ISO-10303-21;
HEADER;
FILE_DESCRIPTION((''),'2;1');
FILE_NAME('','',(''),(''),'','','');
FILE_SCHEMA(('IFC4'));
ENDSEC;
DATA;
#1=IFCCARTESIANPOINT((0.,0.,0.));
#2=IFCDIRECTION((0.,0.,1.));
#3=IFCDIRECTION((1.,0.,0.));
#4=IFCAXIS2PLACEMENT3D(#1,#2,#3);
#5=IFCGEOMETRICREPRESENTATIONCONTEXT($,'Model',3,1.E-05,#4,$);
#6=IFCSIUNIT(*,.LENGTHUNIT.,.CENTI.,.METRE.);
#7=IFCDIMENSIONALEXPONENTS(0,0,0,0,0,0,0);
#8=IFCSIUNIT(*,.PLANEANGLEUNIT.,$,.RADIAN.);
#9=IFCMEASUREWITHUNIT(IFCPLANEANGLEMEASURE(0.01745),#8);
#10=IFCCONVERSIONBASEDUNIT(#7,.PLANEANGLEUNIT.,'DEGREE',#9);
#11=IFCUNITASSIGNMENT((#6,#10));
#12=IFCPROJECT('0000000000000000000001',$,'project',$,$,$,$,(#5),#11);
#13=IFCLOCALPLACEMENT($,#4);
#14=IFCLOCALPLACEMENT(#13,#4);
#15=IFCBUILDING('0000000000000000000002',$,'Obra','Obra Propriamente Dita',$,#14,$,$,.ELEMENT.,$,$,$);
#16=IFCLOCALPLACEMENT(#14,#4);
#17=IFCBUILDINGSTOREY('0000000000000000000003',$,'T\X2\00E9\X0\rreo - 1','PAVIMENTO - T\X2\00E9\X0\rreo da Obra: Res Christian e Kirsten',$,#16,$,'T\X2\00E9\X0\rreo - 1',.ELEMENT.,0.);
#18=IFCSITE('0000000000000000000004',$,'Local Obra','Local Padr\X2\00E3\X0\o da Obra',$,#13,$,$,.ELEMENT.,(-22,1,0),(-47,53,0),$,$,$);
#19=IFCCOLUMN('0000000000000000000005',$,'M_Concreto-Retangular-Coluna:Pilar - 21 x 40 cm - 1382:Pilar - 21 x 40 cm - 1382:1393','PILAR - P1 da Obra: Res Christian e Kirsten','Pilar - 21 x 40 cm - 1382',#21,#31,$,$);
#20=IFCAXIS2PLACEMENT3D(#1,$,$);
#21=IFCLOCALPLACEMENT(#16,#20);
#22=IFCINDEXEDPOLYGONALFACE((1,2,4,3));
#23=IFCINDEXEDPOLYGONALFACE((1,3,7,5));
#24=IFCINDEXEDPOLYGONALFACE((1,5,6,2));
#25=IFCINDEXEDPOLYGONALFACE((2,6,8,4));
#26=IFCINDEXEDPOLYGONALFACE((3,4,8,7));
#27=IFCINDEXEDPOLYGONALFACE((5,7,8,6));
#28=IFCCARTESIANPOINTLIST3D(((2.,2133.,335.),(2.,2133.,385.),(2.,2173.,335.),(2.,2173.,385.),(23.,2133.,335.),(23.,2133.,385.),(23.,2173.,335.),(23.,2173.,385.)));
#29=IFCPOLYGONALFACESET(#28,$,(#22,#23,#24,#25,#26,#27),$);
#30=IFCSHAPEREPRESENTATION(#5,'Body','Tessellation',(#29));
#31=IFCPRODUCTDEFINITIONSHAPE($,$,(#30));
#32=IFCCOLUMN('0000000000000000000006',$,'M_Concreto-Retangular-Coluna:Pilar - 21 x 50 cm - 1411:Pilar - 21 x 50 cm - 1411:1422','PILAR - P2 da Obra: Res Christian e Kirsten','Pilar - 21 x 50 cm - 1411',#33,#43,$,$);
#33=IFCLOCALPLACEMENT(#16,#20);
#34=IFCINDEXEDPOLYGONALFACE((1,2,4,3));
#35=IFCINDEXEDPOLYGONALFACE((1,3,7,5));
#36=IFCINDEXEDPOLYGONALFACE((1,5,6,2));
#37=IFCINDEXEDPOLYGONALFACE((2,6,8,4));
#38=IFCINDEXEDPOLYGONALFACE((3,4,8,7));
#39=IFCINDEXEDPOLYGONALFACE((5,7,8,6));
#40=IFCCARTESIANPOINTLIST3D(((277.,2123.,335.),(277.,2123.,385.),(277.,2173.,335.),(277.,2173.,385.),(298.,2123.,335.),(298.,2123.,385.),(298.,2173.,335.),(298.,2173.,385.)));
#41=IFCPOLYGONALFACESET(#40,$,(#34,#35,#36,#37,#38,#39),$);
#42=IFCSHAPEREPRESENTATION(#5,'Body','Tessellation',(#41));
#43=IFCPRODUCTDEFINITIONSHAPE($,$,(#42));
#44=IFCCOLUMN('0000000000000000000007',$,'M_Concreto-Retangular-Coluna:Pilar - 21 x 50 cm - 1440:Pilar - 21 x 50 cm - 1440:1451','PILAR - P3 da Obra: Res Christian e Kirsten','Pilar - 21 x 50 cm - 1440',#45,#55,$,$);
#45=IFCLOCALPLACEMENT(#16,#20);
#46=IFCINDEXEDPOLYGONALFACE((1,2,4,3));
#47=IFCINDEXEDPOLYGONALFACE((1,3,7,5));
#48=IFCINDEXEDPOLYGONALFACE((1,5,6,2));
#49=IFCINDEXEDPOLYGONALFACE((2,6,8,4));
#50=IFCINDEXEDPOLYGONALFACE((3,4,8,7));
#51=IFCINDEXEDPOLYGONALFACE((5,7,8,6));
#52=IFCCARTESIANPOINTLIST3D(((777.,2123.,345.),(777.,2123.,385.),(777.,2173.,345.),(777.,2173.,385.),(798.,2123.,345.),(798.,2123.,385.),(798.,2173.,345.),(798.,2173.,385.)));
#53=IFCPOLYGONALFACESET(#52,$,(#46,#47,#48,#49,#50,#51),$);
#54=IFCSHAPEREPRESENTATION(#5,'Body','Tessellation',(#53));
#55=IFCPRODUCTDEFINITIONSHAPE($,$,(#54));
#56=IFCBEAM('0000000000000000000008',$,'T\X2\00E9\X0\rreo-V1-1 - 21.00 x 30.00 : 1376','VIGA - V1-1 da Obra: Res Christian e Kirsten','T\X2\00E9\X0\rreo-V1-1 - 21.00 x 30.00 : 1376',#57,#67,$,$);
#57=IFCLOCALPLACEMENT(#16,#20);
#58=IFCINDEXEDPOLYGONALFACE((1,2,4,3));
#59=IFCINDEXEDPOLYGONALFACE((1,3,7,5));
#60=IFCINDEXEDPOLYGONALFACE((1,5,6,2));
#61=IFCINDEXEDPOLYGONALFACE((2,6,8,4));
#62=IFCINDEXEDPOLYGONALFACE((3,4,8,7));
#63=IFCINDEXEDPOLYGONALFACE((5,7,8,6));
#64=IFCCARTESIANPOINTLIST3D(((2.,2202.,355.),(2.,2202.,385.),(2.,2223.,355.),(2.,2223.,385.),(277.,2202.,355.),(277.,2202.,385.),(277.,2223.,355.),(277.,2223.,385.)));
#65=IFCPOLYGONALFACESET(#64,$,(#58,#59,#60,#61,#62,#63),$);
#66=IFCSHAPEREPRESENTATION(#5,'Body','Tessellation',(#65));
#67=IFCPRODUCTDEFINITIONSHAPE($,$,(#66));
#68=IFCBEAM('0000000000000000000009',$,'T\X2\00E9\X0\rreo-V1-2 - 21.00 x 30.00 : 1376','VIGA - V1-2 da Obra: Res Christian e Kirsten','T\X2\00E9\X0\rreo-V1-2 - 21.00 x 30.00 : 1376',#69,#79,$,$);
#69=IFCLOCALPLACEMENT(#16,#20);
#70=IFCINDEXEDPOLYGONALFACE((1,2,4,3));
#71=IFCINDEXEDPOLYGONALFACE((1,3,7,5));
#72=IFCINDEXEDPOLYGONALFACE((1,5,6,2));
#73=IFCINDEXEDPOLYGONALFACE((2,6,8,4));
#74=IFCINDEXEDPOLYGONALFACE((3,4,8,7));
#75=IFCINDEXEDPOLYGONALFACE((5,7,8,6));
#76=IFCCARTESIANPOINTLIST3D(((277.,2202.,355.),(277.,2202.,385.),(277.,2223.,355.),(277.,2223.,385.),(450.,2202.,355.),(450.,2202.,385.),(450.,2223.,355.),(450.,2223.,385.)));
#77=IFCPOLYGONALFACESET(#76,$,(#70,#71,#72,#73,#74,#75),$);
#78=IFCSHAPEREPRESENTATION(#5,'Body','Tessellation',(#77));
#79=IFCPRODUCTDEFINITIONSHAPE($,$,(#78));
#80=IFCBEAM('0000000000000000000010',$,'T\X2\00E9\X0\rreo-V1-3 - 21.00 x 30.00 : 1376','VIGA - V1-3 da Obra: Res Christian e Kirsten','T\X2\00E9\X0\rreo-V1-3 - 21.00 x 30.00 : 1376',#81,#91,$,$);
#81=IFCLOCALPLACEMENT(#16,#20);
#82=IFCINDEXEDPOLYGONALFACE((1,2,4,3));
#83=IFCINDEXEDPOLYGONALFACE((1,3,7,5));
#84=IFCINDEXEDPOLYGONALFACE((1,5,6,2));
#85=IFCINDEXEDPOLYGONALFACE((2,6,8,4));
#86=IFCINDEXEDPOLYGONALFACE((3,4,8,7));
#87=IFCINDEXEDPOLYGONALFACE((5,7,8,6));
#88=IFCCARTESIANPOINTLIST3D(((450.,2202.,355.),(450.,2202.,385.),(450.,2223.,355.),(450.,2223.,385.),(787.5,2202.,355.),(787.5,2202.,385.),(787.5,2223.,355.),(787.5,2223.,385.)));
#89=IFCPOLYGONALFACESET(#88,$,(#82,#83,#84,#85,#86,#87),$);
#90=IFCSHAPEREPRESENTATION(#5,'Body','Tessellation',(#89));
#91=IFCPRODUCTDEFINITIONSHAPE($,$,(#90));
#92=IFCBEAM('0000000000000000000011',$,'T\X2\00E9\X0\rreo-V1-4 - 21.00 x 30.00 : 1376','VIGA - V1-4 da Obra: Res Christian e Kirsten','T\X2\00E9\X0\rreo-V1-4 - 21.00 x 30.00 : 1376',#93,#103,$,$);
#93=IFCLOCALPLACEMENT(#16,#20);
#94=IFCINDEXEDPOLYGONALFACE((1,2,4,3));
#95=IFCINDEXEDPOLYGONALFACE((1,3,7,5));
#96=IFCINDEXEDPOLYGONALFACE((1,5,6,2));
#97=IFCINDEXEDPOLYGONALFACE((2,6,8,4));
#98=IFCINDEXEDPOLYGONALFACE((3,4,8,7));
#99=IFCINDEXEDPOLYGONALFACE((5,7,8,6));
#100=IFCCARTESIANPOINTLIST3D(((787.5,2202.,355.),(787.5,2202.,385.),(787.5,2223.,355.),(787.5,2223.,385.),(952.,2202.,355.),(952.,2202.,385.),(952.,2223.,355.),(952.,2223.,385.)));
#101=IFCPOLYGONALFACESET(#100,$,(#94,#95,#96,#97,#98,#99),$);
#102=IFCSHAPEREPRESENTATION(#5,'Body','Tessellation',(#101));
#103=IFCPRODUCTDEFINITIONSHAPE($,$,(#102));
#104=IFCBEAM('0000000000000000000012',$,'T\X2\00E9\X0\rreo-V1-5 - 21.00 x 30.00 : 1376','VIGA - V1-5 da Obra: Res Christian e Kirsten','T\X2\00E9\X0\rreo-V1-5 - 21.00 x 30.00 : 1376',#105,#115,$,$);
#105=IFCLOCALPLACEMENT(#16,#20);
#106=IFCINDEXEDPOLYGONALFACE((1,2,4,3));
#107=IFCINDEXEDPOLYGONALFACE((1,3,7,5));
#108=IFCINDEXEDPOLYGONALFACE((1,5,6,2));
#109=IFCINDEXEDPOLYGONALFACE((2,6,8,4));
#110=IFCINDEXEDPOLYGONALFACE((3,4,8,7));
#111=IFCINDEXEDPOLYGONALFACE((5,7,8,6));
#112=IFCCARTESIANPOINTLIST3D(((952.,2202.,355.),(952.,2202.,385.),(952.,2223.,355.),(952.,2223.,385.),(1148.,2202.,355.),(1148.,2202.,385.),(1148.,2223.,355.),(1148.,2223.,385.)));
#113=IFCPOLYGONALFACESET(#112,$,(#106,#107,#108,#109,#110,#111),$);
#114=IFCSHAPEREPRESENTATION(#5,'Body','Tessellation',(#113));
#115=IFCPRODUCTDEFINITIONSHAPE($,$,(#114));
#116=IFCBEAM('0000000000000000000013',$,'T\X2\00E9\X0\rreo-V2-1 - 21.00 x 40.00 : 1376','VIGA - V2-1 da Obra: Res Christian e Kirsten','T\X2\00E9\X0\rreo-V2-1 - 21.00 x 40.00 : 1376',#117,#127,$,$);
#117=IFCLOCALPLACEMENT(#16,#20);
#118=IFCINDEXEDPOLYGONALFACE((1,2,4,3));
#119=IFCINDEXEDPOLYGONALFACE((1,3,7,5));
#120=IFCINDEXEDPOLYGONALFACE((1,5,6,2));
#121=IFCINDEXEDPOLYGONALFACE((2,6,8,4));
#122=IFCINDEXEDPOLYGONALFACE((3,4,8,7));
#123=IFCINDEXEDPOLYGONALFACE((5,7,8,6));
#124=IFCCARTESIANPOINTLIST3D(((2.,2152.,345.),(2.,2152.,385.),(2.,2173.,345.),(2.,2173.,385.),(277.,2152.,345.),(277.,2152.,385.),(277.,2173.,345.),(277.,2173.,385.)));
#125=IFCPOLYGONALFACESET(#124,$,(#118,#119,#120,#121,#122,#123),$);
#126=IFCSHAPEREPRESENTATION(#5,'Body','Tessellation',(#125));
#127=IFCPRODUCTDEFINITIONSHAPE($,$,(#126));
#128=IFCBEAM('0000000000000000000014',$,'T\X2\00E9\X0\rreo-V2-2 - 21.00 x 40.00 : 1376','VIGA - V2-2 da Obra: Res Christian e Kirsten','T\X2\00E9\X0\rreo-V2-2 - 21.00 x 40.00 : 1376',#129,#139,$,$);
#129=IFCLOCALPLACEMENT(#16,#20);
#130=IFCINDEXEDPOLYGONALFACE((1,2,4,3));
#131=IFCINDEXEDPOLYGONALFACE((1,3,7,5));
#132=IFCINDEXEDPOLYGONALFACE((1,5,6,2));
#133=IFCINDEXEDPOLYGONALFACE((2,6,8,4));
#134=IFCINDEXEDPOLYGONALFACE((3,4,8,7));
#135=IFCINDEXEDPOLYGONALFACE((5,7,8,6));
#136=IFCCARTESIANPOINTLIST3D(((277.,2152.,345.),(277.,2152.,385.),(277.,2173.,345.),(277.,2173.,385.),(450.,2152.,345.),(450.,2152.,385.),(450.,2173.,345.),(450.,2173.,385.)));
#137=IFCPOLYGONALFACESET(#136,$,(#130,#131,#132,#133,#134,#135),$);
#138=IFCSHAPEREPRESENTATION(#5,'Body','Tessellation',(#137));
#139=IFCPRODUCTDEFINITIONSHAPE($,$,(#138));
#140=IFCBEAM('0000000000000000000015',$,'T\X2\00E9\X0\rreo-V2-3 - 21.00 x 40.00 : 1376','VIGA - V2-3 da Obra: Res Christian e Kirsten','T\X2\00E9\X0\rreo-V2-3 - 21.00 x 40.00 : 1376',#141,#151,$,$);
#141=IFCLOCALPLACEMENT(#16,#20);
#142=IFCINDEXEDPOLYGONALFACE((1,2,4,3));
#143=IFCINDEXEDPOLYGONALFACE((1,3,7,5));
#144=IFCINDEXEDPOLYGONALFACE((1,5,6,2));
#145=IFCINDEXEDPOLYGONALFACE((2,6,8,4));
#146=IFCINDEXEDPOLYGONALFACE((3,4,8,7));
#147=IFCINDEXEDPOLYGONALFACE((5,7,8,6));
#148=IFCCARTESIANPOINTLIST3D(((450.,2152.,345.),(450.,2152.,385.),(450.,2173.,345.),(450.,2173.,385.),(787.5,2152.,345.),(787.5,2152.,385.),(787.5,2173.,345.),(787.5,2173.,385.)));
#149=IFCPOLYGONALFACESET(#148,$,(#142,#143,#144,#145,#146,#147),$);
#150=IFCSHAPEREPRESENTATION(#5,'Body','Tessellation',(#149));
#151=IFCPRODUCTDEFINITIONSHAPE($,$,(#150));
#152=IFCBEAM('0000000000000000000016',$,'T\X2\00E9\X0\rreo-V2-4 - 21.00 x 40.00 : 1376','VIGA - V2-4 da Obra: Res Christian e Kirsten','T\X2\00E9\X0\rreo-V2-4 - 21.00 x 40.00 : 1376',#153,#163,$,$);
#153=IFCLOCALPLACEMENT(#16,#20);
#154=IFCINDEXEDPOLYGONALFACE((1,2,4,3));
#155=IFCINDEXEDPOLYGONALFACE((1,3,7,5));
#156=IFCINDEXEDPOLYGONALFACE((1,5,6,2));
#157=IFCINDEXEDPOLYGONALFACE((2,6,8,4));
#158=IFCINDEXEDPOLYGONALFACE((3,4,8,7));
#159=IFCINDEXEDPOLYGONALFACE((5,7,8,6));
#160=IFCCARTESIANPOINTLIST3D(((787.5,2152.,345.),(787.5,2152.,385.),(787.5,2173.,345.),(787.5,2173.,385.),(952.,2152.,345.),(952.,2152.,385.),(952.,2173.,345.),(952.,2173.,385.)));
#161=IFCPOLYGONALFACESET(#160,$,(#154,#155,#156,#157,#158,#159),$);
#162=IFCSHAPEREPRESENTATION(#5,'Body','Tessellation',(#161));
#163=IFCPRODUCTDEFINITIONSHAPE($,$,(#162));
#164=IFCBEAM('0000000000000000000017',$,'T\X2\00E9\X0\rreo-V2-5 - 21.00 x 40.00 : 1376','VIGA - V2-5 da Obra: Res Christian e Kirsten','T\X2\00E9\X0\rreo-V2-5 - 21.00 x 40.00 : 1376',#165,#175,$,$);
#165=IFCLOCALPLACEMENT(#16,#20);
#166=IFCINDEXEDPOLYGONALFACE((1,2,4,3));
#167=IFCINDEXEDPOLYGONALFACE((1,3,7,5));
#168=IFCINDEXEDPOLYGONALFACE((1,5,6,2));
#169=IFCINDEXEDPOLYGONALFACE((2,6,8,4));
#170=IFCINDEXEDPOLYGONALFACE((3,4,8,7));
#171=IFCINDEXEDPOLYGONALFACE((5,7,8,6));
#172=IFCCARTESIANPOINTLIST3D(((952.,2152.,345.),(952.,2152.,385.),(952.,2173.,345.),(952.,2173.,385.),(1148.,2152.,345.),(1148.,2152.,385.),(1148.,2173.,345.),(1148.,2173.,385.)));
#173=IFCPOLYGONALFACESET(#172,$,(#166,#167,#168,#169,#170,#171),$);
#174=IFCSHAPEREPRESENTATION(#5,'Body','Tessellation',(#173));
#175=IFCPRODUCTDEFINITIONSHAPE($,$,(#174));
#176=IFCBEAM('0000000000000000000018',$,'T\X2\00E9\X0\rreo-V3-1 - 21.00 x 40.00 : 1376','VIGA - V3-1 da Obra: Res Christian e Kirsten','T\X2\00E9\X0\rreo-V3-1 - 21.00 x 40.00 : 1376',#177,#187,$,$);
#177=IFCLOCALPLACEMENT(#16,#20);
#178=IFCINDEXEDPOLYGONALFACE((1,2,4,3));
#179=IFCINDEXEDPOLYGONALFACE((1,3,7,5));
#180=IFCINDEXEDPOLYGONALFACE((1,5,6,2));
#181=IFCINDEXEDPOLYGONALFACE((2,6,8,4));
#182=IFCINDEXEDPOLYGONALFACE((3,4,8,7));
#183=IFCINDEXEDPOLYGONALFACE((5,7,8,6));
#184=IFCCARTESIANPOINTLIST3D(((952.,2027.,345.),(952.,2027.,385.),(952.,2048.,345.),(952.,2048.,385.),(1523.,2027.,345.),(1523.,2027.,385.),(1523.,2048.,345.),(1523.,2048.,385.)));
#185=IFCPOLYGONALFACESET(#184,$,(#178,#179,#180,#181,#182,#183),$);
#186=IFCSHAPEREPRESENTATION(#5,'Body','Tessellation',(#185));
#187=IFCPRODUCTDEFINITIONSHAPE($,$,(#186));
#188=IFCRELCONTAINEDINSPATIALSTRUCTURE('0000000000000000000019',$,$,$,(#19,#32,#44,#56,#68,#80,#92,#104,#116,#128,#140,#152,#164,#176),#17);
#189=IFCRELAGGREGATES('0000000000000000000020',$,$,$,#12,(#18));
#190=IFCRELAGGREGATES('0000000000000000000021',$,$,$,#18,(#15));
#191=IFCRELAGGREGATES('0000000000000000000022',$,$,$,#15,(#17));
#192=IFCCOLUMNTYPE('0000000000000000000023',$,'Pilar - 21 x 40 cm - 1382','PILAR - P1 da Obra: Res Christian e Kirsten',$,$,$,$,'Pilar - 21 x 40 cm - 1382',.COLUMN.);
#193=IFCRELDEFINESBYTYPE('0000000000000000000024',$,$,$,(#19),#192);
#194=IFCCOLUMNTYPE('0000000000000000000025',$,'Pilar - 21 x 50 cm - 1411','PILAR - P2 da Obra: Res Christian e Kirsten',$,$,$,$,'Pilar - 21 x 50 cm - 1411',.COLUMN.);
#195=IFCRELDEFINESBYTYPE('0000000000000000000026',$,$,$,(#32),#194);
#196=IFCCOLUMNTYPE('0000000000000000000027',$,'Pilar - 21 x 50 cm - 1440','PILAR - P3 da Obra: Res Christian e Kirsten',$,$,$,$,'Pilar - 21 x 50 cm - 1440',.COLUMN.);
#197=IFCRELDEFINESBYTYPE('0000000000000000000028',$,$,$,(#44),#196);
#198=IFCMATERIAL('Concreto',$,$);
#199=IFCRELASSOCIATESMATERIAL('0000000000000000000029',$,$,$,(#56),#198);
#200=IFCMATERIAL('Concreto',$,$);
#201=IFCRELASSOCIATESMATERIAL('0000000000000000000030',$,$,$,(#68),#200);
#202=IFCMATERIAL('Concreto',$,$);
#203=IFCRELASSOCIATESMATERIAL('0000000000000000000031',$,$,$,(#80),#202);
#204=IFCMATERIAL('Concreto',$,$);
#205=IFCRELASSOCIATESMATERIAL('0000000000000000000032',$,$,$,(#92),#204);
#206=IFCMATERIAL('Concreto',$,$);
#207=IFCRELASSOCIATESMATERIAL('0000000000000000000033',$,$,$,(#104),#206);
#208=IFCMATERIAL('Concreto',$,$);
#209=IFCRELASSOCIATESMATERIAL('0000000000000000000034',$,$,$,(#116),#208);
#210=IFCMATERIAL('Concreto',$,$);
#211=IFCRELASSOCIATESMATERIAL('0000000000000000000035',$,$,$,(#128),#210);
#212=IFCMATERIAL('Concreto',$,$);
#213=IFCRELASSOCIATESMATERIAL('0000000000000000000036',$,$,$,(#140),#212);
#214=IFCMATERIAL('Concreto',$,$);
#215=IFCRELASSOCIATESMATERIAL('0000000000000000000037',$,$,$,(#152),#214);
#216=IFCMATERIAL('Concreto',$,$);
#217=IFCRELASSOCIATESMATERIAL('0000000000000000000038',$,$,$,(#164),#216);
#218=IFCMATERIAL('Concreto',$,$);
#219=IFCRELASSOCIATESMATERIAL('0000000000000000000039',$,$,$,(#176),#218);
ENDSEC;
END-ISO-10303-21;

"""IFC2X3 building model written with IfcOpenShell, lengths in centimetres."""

from ifc_helpers import new_model, entity, si_unit, converted_unit, frame, origin, origin_with_axes, origin_2d_with_axis, place, context, project, spatial, polyline, rectangle, outline, extrude, source, transform, mapped, material, type_object, type_shapes, element, save


model = new_model("IFC2X3")

# Units and contexts
model_context = context("Model", 3, precision=1e-05, world=origin_with_axes())
ifc_project = project(units=[si_unit("LENGTHUNIT", "METRE", prefix="CENTI"), converted_unit("PLANEANGLEUNIT", "DEGREE", entity("IfcPlaneAngleMeasure", 0.01745), si_unit("PLANEANGLEUNIT", "RADIAN"), dimensions=[0, 0, 0, 0, 0, 0, 0])], contexts=[model_context])

# Site, building, storey
site_placement = place(None, origin_with_axes())
site = spatial("IfcSite", under=ifc_project, at=site_placement, Name="Local Obra", Description="Local Padrão da Obra", CompositionType="ELEMENT", RefLatitude=(-22, 1, 0), RefLongitude=(-47, 53, 0))
building_placement = place(site_placement, origin_with_axes())
building = spatial("IfcBuilding", under=site, at=building_placement, Name="Obra", Description="Obra Propriamente Dita", CompositionType="ELEMENT")
storey_placement = place(building_placement, origin_with_axes())
storey = spatial("IfcBuildingStorey", under=building, at=storey_placement, Name="Térreo - 1", Description="PAVIMENTO - Térreo da Obra: Res Christian e Kirsten", LongName="Térreo - 1", CompositionType="ELEMENT", Elevation=0.0)

# Columns
column_type_1 = type_object("IfcColumnType", Name="Pilar - 21 x 40 cm - 1382", Description="PILAR - P1 da Obra: Res Christian e Kirsten", ElementType="Pilar - 21 x 40 cm - 1382", PredefinedType="COLUMN")
shared_shape_1 = source(origin(), model_context, "Body", "SweptSolid", [
    extrude(rectangle(XDim=21.0, YDim=40.0, at=origin_2d_with_axis()), origin(), (0.0, 0.0, 1.0), 50.0),
])
type_shapes(column_type_1, [shared_shape_1])
column_1_placement = place(storey_placement, frame((12.5, 2153.0, 335.0), z_axis=(0.0, 0.0, 1.0), x_axis=(1.0, 0.0, 0.0)))
element("IfcColumn", 1, at=column_1_placement, inside=storey, type_object=column_type_1, Name="M_Concreto-Retangular-Coluna:Pilar - 21 x 40 cm - 1382:Pilar - 21 x 40 cm - 1382:1393", Description="PILAR - P1 da Obra: Res Christian e Kirsten", ObjectType="Pilar - 21 x 40 cm - 1382", context=model_context, shape_type="MappedRepresentation", body=[
    mapped(shared_shape_1, transform((0.0, 0.0, 0.0), scale=1.0)),
])
column_type_2 = type_object("IfcColumnType", Name="Pilar - 21 x 50 cm - 1411", Description="PILAR - P2 da Obra: Res Christian e Kirsten", ElementType="Pilar - 21 x 50 cm - 1411", PredefinedType="COLUMN")
shared_shape_2 = source(origin(), model_context, "Body", "SweptSolid", [
    extrude(rectangle(XDim=21.0, YDim=50.0, at=origin_2d_with_axis()), origin(), (0.0, 0.0, 1.0), 50.0),
])
type_shapes(column_type_2, [shared_shape_2])
column_2_placement = place(storey_placement, frame((287.5, 2148.0, 335.0), z_axis=(0.0, 0.0, 1.0), x_axis=(1.0, 0.0, 0.0)))
element("IfcColumn", 2, at=column_2_placement, inside=storey, type_object=column_type_2, Name="M_Concreto-Retangular-Coluna:Pilar - 21 x 50 cm - 1411:Pilar - 21 x 50 cm - 1411:1422", Description="PILAR - P2 da Obra: Res Christian e Kirsten", ObjectType="Pilar - 21 x 50 cm - 1411", context=model_context, shape_type="MappedRepresentation", body=[
    mapped(shared_shape_2, transform((0.0, 0.0, 0.0), scale=1.0)),
])
column_type_3 = type_object("IfcColumnType", Name="Pilar - 21 x 50 cm - 1440", Description="PILAR - P3 da Obra: Res Christian e Kirsten", ElementType="Pilar - 21 x 50 cm - 1440", PredefinedType="COLUMN")
shared_shape_3 = source(origin(), model_context, "Body", "SweptSolid", [
    extrude(rectangle(XDim=21.0, YDim=50.0, at=origin_2d_with_axis()), origin(), (0.0, 0.0, 1.0), 40.0),
])
type_shapes(column_type_3, [shared_shape_3])
column_3_placement = place(storey_placement, frame((787.5, 2148.0, 345.0), z_axis=(0.0, 0.0, 1.0), x_axis=(1.0, 0.0, 0.0)))
element("IfcColumn", 3, at=column_3_placement, inside=storey, type_object=column_type_3, Name="M_Concreto-Retangular-Coluna:Pilar - 21 x 50 cm - 1440:Pilar - 21 x 50 cm - 1440:1451", Description="PILAR - P3 da Obra: Res Christian e Kirsten", ObjectType="Pilar - 21 x 50 cm - 1440", context=model_context, shape_type="MappedRepresentation", body=[
    mapped(shared_shape_3, transform((0.0, 0.0, 0.0), scale=1.0)),
])

# Beams
ifc_material_1 = material(Name="Concreto")
beam_1_placement = place(storey_placement, frame((2.0, 2223.0, 385.0), z_axis=(1.0, 0.0, 0.0), x_axis=(0.0, -1.0, 0.0)))
element("IfcBeam", 4, at=beam_1_placement, inside=storey, material=ifc_material_1, Name="Térreo-V1-1 - 21.00 x 30.00 : 1376", Description="VIGA - V1-1 da Obra: Res Christian e Kirsten", ObjectType="Térreo-V1-1 - 21.00 x 30.00 : 1376", context=model_context, shape_type="SweptSolid", body=[
    extrude(outline(polyline([(0.0, 0.0), (21.0, 0.0), (21.0, 30.0), (0.0, 30.0), (0.0, 0.0)])), origin_with_axes(), (0.0, 0.0, 1.0), 275.0),
])
ifc_material_2 = material(Name="Concreto")
beam_2_placement = place(storey_placement, frame((277.0, 2223.0, 385.0), z_axis=(1.0, 0.0, 0.0), x_axis=(0.0, -1.0, 0.0)))
element("IfcBeam", 5, at=beam_2_placement, inside=storey, material=ifc_material_2, Name="Térreo-V1-2 - 21.00 x 30.00 : 1376", Description="VIGA - V1-2 da Obra: Res Christian e Kirsten", ObjectType="Térreo-V1-2 - 21.00 x 30.00 : 1376", context=model_context, shape_type="SweptSolid", body=[
    extrude(outline(polyline([(0.0, 0.0), (21.0, 0.0), (21.0, 30.0), (0.0, 30.0), (0.0, 0.0)])), origin_with_axes(), (0.0, 0.0, 1.0), 173.0),
])
ifc_material_3 = material(Name="Concreto")
beam_3_placement = place(storey_placement, frame((450.0, 2223.0, 385.0), z_axis=(1.0, 0.0, 0.0), x_axis=(0.0, -1.0, 0.0)))
element("IfcBeam", 6, at=beam_3_placement, inside=storey, material=ifc_material_3, Name="Térreo-V1-3 - 21.00 x 30.00 : 1376", Description="VIGA - V1-3 da Obra: Res Christian e Kirsten", ObjectType="Térreo-V1-3 - 21.00 x 30.00 : 1376", context=model_context, shape_type="SweptSolid", body=[
    extrude(outline(polyline([(0.0, 0.0), (21.0, 0.0), (21.0, 30.0), (0.0, 30.0), (0.0, 0.0)])), origin_with_axes(), (0.0, 0.0, 1.0), 337.5),
])
ifc_material_4 = material(Name="Concreto")
beam_4_placement = place(storey_placement, frame((787.5, 2223.0, 385.0), z_axis=(1.0, 0.0, 0.0), x_axis=(0.0, -1.0, 0.0)))
element("IfcBeam", 7, at=beam_4_placement, inside=storey, material=ifc_material_4, Name="Térreo-V1-4 - 21.00 x 30.00 : 1376", Description="VIGA - V1-4 da Obra: Res Christian e Kirsten", ObjectType="Térreo-V1-4 - 21.00 x 30.00 : 1376", context=model_context, shape_type="SweptSolid", body=[
    extrude(outline(polyline([(0.0, 0.0), (21.0, 0.0), (21.0, 30.0), (0.0, 30.0), (0.0, 0.0)])), origin_with_axes(), (0.0, 0.0, 1.0), 164.5),
])
ifc_material_5 = material(Name="Concreto")
beam_5_placement = place(storey_placement, frame((952.0, 2223.0, 385.0), z_axis=(1.0, 0.0, 0.0), x_axis=(0.0, -1.0, 0.0)))
element("IfcBeam", 8, at=beam_5_placement, inside=storey, material=ifc_material_5, Name="Térreo-V1-5 - 21.00 x 30.00 : 1376", Description="VIGA - V1-5 da Obra: Res Christian e Kirsten", ObjectType="Térreo-V1-5 - 21.00 x 30.00 : 1376", context=model_context, shape_type="SweptSolid", body=[
    extrude(outline(polyline([(0.0, 0.0), (21.0, 0.0), (21.0, 30.0), (0.0, 30.0), (0.0, 0.0)])), origin_with_axes(), (0.0, 0.0, 1.0), 196.0),
])
ifc_material_6 = material(Name="Concreto")
beam_6_placement = place(storey_placement, frame((2.0, 2173.0, 385.0), z_axis=(1.0, 0.0, 0.0), x_axis=(0.0, -1.0, 0.0)))
element("IfcBeam", 9, at=beam_6_placement, inside=storey, material=ifc_material_6, Name="Térreo-V2-1 - 21.00 x 40.00 : 1376", Description="VIGA - V2-1 da Obra: Res Christian e Kirsten", ObjectType="Térreo-V2-1 - 21.00 x 40.00 : 1376", context=model_context, shape_type="SweptSolid", body=[
    extrude(outline(polyline([(0.0, 0.0), (21.0, 0.0), (21.0, 40.0), (0.0, 40.0), (0.0, 0.0)])), origin_with_axes(), (0.0, 0.0, 1.0), 275.0),
])
ifc_material_7 = material(Name="Concreto")
beam_7_placement = place(storey_placement, frame((277.0, 2173.0, 385.0), z_axis=(1.0, 0.0, 0.0), x_axis=(0.0, -1.0, 0.0)))
element("IfcBeam", 10, at=beam_7_placement, inside=storey, material=ifc_material_7, Name="Térreo-V2-2 - 21.00 x 40.00 : 1376", Description="VIGA - V2-2 da Obra: Res Christian e Kirsten", ObjectType="Térreo-V2-2 - 21.00 x 40.00 : 1376", context=model_context, shape_type="SweptSolid", body=[
    extrude(outline(polyline([(0.0, 0.0), (21.0, 0.0), (21.0, 40.0), (0.0, 40.0), (0.0, 0.0)])), origin_with_axes(), (0.0, 0.0, 1.0), 173.0),
])
ifc_material_8 = material(Name="Concreto")
beam_8_placement = place(storey_placement, frame((450.0, 2173.0, 385.0), z_axis=(1.0, 0.0, 0.0), x_axis=(0.0, -1.0, 0.0)))
element("IfcBeam", 11, at=beam_8_placement, inside=storey, material=ifc_material_8, Name="Térreo-V2-3 - 21.00 x 40.00 : 1376", Description="VIGA - V2-3 da Obra: Res Christian e Kirsten", ObjectType="Térreo-V2-3 - 21.00 x 40.00 : 1376", context=model_context, shape_type="SweptSolid", body=[
    extrude(outline(polyline([(0.0, 0.0), (21.0, 0.0), (21.0, 40.0), (0.0, 40.0), (0.0, 0.0)])), origin_with_axes(), (0.0, 0.0, 1.0), 337.5),
])
ifc_material_9 = material(Name="Concreto")
beam_9_placement = place(storey_placement, frame((787.5, 2173.0, 385.0), z_axis=(1.0, 0.0, 0.0), x_axis=(0.0, -1.0, 0.0)))
element("IfcBeam", 12, at=beam_9_placement, inside=storey, material=ifc_material_9, Name="Térreo-V2-4 - 21.00 x 40.00 : 1376", Description="VIGA - V2-4 da Obra: Res Christian e Kirsten", ObjectType="Térreo-V2-4 - 21.00 x 40.00 : 1376", context=model_context, shape_type="SweptSolid", body=[
    extrude(outline(polyline([(0.0, 0.0), (21.0, 0.0), (21.0, 40.0), (0.0, 40.0), (0.0, 0.0)])), origin_with_axes(), (0.0, 0.0, 1.0), 164.5),
])
ifc_material_10 = material(Name="Concreto")
beam_10_placement = place(storey_placement, frame((952.0, 2173.0, 385.0), z_axis=(1.0, 0.0, 0.0), x_axis=(0.0, -1.0, 0.0)))
element("IfcBeam", 13, at=beam_10_placement, inside=storey, material=ifc_material_10, Name="Térreo-V2-5 - 21.00 x 40.00 : 1376", Description="VIGA - V2-5 da Obra: Res Christian e Kirsten", ObjectType="Térreo-V2-5 - 21.00 x 40.00 : 1376", context=model_context, shape_type="SweptSolid", body=[
    extrude(outline(polyline([(0.0, 0.0), (21.0, 0.0), (21.0, 40.0), (0.0, 40.0), (0.0, 0.0)])), origin_with_axes(), (0.0, 0.0, 1.0), 196.0),
])
ifc_material_11 = material(Name="Concreto")
beam_11_placement = place(storey_placement, frame((952.0, 2048.0, 385.0), z_axis=(1.0, 0.0, 0.0), x_axis=(0.0, -1.0, 0.0)))
element("IfcBeam", 14, at=beam_11_placement, inside=storey, material=ifc_material_11, Name="Térreo-V3-1 - 21.00 x 40.00 : 1376", Description="VIGA - V3-1 da Obra: Res Christian e Kirsten", ObjectType="Térreo-V3-1 - 21.00 x 40.00 : 1376", context=model_context, shape_type="SweptSolid", body=[
    extrude(outline(polyline([(0.0, 0.0), (21.0, 0.0), (21.0, 40.0), (0.0, 40.0), (0.0, 0.0)])), origin_with_axes(), (0.0, 0.0, 1.0), 571.0),
])

save(model, "model.ifc")
